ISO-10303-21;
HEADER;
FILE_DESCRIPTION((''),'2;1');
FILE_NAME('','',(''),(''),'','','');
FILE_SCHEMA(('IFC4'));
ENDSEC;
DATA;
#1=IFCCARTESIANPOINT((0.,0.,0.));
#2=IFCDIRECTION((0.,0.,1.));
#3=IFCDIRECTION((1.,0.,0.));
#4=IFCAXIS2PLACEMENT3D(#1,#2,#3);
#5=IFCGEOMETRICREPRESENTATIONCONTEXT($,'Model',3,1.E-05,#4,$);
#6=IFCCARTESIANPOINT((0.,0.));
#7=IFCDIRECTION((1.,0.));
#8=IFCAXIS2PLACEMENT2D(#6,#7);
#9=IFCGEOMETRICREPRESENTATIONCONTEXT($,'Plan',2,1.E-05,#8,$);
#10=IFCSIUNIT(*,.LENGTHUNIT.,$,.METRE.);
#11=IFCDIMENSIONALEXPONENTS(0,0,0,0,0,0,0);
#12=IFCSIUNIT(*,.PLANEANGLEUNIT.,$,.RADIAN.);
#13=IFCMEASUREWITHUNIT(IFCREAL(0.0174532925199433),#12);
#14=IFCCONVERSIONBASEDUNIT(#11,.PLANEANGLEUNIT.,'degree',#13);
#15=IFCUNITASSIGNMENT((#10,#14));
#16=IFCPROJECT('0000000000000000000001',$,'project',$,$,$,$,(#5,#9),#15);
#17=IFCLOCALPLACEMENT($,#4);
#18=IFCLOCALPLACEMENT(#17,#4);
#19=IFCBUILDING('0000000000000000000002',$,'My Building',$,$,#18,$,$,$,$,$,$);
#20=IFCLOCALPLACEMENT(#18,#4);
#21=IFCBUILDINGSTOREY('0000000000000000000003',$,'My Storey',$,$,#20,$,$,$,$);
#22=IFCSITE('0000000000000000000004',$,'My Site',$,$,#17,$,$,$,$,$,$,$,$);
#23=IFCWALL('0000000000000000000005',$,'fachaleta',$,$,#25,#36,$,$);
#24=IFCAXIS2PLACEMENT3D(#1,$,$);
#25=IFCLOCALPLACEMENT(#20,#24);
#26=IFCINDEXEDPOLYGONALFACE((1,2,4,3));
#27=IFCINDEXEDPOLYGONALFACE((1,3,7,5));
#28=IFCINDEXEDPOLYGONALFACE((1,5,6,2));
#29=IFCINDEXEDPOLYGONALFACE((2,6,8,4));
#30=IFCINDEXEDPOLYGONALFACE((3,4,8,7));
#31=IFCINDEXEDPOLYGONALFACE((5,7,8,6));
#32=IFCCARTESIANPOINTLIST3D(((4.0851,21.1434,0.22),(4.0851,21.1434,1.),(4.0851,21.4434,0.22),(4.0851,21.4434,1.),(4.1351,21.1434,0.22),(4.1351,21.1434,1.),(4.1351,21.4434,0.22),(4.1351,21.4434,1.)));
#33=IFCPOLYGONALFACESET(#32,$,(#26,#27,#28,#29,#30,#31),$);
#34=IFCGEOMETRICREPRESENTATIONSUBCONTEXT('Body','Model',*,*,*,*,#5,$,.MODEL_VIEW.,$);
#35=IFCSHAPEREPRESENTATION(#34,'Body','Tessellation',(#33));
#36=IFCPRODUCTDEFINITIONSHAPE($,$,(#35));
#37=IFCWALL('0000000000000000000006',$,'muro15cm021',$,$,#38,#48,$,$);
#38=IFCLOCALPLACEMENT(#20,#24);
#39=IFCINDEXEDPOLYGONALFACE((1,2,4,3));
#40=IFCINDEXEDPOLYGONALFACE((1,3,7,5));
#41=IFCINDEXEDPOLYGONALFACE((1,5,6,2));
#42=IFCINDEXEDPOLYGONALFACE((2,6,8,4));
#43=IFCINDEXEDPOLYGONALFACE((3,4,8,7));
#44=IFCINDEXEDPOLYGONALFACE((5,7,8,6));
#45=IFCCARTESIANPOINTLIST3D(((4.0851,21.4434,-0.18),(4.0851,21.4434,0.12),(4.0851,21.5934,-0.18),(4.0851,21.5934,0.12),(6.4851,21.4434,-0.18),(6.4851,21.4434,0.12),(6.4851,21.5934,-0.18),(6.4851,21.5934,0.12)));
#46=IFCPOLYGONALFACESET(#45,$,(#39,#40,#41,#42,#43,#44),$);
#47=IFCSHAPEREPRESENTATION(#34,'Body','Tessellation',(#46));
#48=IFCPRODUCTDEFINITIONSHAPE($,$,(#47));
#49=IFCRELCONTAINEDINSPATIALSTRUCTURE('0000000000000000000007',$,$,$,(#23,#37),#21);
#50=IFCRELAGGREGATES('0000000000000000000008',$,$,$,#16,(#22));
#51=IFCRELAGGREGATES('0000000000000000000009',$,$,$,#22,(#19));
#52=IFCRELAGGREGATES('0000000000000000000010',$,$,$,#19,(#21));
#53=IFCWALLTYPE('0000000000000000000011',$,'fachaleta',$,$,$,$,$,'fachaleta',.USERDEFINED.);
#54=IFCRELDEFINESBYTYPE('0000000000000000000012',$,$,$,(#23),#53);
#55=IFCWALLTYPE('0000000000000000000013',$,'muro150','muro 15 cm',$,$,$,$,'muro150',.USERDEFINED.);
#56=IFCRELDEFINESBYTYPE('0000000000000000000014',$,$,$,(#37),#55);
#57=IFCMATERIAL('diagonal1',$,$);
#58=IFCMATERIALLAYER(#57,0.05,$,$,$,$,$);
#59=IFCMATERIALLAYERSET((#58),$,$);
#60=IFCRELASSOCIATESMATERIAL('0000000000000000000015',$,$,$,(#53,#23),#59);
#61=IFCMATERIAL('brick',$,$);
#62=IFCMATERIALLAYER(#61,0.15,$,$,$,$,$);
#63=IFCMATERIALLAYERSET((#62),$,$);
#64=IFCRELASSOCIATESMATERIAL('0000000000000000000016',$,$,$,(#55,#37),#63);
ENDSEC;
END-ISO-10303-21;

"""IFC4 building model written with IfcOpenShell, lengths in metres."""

from ifc_helpers import new_model, entity, si_unit, converted_unit, frame, origin_with_axes, origin_2d_with_axis, place, context, subcontext, project, spatial, indexed_curve, outline, extrude, material, layer, layer_set, layer_usage, type_object, element, save


model = new_model("IFC4")

# Units and contexts
model_context = context("Model", 3, precision=1e-05, world=origin_with_axes())
plan_context = context("Plan", 2, precision=1e-05, world=origin_2d_with_axis())
body_context = subcontext(model_context, "Body", "Model", "MODEL_VIEW")
ifc_project = project(units=[si_unit("LENGTHUNIT", "METRE"), converted_unit("PLANEANGLEUNIT", "degree", entity("IfcReal", 0.0174532925199433), si_unit("PLANEANGLEUNIT", "RADIAN"), dimensions=[0, 0, 0, 0, 0, 0, 0])], contexts=[model_context, plan_context])

# Site, building, storey
site_placement = place(None, origin_with_axes())
site = spatial("IfcSite", under=ifc_project, at=site_placement, Name="My Site")
building_placement = place(site_placement, origin_with_axes())
building = spatial("IfcBuilding", under=site, at=building_placement, Name="My Building")
storey_placement = place(building_placement, origin_with_axes())
storey = spatial("IfcBuildingStorey", under=building, at=storey_placement, Name="My Storey")

# Walls
ifc_material_1 = material(Name="diagonal1")
ifc_layer_1 = layer(ifc_material_1, 0.05)
ifc_layer_set_1 = layer_set([ifc_layer_1])
wall_type_1 = type_object("IfcWallType", Name="fachaleta", ElementType="fachaleta", PredefinedType="USERDEFINED", material=ifc_layer_set_1)
ifc_layer_usage_1 = layer_usage(ifc_layer_set_1, "AXIS2", "POSITIVE", 0.0)
wall_1_placement = place(storey_placement, frame((4.1351, 21.1434, 0.22), z_axis=(0.0, 0.0, 1.0), x_axis=(0.000001, 1.0, 0.0)))
element("IfcWall", 1, at=wall_1_placement, inside=storey, type_object=wall_type_1, material=ifc_layer_usage_1, Name="fachaleta", context=body_context, shape_type="SweptSolid", body=[
    extrude(outline(indexed_curve([(0.0, 0.0), (0.0, 0.05), (0.3, 0.05), (0.3, 0.0), (0.0, 0.0)], self_intersect=False)), origin_with_axes(), (0.0, 0.0, 1.0), 0.78),
])
ifc_material_2 = material(Name="brick")
ifc_layer_2 = layer(ifc_material_2, 0.15)
ifc_layer_set_2 = layer_set([ifc_layer_2])
ifc_layer_usage_2 = layer_usage(ifc_layer_set_2, "AXIS2", "POSITIVE", 0.0)
wall_type_2 = type_object("IfcWallType", Name="muro150", Description="muro 15 cm", ElementType="muro150", PredefinedType="USERDEFINED", material=ifc_layer_set_2)
wall_2_placement = place(storey_placement, frame((6.4851, 21.5934, -0.18), z_axis=(0.0, 0.0, 1.0), x_axis=(-1.0, 0.000001, 0.0)))
element("IfcWall", 2, at=wall_2_placement, inside=storey, type_object=wall_type_2, material=ifc_layer_usage_2, Name="muro15cm021", context=body_context, shape_type="SweptSolid", body=[
    extrude(outline(indexed_curve([(0.0, 0.0), (0.0, 0.15), (2.4, 0.15), (2.4, 0.0), (0.0, 0.0)], self_intersect=False)), origin_with_axes(), (0.0, 0.0, 1.0), 0.3),
])

save(model, "model.ifc")
